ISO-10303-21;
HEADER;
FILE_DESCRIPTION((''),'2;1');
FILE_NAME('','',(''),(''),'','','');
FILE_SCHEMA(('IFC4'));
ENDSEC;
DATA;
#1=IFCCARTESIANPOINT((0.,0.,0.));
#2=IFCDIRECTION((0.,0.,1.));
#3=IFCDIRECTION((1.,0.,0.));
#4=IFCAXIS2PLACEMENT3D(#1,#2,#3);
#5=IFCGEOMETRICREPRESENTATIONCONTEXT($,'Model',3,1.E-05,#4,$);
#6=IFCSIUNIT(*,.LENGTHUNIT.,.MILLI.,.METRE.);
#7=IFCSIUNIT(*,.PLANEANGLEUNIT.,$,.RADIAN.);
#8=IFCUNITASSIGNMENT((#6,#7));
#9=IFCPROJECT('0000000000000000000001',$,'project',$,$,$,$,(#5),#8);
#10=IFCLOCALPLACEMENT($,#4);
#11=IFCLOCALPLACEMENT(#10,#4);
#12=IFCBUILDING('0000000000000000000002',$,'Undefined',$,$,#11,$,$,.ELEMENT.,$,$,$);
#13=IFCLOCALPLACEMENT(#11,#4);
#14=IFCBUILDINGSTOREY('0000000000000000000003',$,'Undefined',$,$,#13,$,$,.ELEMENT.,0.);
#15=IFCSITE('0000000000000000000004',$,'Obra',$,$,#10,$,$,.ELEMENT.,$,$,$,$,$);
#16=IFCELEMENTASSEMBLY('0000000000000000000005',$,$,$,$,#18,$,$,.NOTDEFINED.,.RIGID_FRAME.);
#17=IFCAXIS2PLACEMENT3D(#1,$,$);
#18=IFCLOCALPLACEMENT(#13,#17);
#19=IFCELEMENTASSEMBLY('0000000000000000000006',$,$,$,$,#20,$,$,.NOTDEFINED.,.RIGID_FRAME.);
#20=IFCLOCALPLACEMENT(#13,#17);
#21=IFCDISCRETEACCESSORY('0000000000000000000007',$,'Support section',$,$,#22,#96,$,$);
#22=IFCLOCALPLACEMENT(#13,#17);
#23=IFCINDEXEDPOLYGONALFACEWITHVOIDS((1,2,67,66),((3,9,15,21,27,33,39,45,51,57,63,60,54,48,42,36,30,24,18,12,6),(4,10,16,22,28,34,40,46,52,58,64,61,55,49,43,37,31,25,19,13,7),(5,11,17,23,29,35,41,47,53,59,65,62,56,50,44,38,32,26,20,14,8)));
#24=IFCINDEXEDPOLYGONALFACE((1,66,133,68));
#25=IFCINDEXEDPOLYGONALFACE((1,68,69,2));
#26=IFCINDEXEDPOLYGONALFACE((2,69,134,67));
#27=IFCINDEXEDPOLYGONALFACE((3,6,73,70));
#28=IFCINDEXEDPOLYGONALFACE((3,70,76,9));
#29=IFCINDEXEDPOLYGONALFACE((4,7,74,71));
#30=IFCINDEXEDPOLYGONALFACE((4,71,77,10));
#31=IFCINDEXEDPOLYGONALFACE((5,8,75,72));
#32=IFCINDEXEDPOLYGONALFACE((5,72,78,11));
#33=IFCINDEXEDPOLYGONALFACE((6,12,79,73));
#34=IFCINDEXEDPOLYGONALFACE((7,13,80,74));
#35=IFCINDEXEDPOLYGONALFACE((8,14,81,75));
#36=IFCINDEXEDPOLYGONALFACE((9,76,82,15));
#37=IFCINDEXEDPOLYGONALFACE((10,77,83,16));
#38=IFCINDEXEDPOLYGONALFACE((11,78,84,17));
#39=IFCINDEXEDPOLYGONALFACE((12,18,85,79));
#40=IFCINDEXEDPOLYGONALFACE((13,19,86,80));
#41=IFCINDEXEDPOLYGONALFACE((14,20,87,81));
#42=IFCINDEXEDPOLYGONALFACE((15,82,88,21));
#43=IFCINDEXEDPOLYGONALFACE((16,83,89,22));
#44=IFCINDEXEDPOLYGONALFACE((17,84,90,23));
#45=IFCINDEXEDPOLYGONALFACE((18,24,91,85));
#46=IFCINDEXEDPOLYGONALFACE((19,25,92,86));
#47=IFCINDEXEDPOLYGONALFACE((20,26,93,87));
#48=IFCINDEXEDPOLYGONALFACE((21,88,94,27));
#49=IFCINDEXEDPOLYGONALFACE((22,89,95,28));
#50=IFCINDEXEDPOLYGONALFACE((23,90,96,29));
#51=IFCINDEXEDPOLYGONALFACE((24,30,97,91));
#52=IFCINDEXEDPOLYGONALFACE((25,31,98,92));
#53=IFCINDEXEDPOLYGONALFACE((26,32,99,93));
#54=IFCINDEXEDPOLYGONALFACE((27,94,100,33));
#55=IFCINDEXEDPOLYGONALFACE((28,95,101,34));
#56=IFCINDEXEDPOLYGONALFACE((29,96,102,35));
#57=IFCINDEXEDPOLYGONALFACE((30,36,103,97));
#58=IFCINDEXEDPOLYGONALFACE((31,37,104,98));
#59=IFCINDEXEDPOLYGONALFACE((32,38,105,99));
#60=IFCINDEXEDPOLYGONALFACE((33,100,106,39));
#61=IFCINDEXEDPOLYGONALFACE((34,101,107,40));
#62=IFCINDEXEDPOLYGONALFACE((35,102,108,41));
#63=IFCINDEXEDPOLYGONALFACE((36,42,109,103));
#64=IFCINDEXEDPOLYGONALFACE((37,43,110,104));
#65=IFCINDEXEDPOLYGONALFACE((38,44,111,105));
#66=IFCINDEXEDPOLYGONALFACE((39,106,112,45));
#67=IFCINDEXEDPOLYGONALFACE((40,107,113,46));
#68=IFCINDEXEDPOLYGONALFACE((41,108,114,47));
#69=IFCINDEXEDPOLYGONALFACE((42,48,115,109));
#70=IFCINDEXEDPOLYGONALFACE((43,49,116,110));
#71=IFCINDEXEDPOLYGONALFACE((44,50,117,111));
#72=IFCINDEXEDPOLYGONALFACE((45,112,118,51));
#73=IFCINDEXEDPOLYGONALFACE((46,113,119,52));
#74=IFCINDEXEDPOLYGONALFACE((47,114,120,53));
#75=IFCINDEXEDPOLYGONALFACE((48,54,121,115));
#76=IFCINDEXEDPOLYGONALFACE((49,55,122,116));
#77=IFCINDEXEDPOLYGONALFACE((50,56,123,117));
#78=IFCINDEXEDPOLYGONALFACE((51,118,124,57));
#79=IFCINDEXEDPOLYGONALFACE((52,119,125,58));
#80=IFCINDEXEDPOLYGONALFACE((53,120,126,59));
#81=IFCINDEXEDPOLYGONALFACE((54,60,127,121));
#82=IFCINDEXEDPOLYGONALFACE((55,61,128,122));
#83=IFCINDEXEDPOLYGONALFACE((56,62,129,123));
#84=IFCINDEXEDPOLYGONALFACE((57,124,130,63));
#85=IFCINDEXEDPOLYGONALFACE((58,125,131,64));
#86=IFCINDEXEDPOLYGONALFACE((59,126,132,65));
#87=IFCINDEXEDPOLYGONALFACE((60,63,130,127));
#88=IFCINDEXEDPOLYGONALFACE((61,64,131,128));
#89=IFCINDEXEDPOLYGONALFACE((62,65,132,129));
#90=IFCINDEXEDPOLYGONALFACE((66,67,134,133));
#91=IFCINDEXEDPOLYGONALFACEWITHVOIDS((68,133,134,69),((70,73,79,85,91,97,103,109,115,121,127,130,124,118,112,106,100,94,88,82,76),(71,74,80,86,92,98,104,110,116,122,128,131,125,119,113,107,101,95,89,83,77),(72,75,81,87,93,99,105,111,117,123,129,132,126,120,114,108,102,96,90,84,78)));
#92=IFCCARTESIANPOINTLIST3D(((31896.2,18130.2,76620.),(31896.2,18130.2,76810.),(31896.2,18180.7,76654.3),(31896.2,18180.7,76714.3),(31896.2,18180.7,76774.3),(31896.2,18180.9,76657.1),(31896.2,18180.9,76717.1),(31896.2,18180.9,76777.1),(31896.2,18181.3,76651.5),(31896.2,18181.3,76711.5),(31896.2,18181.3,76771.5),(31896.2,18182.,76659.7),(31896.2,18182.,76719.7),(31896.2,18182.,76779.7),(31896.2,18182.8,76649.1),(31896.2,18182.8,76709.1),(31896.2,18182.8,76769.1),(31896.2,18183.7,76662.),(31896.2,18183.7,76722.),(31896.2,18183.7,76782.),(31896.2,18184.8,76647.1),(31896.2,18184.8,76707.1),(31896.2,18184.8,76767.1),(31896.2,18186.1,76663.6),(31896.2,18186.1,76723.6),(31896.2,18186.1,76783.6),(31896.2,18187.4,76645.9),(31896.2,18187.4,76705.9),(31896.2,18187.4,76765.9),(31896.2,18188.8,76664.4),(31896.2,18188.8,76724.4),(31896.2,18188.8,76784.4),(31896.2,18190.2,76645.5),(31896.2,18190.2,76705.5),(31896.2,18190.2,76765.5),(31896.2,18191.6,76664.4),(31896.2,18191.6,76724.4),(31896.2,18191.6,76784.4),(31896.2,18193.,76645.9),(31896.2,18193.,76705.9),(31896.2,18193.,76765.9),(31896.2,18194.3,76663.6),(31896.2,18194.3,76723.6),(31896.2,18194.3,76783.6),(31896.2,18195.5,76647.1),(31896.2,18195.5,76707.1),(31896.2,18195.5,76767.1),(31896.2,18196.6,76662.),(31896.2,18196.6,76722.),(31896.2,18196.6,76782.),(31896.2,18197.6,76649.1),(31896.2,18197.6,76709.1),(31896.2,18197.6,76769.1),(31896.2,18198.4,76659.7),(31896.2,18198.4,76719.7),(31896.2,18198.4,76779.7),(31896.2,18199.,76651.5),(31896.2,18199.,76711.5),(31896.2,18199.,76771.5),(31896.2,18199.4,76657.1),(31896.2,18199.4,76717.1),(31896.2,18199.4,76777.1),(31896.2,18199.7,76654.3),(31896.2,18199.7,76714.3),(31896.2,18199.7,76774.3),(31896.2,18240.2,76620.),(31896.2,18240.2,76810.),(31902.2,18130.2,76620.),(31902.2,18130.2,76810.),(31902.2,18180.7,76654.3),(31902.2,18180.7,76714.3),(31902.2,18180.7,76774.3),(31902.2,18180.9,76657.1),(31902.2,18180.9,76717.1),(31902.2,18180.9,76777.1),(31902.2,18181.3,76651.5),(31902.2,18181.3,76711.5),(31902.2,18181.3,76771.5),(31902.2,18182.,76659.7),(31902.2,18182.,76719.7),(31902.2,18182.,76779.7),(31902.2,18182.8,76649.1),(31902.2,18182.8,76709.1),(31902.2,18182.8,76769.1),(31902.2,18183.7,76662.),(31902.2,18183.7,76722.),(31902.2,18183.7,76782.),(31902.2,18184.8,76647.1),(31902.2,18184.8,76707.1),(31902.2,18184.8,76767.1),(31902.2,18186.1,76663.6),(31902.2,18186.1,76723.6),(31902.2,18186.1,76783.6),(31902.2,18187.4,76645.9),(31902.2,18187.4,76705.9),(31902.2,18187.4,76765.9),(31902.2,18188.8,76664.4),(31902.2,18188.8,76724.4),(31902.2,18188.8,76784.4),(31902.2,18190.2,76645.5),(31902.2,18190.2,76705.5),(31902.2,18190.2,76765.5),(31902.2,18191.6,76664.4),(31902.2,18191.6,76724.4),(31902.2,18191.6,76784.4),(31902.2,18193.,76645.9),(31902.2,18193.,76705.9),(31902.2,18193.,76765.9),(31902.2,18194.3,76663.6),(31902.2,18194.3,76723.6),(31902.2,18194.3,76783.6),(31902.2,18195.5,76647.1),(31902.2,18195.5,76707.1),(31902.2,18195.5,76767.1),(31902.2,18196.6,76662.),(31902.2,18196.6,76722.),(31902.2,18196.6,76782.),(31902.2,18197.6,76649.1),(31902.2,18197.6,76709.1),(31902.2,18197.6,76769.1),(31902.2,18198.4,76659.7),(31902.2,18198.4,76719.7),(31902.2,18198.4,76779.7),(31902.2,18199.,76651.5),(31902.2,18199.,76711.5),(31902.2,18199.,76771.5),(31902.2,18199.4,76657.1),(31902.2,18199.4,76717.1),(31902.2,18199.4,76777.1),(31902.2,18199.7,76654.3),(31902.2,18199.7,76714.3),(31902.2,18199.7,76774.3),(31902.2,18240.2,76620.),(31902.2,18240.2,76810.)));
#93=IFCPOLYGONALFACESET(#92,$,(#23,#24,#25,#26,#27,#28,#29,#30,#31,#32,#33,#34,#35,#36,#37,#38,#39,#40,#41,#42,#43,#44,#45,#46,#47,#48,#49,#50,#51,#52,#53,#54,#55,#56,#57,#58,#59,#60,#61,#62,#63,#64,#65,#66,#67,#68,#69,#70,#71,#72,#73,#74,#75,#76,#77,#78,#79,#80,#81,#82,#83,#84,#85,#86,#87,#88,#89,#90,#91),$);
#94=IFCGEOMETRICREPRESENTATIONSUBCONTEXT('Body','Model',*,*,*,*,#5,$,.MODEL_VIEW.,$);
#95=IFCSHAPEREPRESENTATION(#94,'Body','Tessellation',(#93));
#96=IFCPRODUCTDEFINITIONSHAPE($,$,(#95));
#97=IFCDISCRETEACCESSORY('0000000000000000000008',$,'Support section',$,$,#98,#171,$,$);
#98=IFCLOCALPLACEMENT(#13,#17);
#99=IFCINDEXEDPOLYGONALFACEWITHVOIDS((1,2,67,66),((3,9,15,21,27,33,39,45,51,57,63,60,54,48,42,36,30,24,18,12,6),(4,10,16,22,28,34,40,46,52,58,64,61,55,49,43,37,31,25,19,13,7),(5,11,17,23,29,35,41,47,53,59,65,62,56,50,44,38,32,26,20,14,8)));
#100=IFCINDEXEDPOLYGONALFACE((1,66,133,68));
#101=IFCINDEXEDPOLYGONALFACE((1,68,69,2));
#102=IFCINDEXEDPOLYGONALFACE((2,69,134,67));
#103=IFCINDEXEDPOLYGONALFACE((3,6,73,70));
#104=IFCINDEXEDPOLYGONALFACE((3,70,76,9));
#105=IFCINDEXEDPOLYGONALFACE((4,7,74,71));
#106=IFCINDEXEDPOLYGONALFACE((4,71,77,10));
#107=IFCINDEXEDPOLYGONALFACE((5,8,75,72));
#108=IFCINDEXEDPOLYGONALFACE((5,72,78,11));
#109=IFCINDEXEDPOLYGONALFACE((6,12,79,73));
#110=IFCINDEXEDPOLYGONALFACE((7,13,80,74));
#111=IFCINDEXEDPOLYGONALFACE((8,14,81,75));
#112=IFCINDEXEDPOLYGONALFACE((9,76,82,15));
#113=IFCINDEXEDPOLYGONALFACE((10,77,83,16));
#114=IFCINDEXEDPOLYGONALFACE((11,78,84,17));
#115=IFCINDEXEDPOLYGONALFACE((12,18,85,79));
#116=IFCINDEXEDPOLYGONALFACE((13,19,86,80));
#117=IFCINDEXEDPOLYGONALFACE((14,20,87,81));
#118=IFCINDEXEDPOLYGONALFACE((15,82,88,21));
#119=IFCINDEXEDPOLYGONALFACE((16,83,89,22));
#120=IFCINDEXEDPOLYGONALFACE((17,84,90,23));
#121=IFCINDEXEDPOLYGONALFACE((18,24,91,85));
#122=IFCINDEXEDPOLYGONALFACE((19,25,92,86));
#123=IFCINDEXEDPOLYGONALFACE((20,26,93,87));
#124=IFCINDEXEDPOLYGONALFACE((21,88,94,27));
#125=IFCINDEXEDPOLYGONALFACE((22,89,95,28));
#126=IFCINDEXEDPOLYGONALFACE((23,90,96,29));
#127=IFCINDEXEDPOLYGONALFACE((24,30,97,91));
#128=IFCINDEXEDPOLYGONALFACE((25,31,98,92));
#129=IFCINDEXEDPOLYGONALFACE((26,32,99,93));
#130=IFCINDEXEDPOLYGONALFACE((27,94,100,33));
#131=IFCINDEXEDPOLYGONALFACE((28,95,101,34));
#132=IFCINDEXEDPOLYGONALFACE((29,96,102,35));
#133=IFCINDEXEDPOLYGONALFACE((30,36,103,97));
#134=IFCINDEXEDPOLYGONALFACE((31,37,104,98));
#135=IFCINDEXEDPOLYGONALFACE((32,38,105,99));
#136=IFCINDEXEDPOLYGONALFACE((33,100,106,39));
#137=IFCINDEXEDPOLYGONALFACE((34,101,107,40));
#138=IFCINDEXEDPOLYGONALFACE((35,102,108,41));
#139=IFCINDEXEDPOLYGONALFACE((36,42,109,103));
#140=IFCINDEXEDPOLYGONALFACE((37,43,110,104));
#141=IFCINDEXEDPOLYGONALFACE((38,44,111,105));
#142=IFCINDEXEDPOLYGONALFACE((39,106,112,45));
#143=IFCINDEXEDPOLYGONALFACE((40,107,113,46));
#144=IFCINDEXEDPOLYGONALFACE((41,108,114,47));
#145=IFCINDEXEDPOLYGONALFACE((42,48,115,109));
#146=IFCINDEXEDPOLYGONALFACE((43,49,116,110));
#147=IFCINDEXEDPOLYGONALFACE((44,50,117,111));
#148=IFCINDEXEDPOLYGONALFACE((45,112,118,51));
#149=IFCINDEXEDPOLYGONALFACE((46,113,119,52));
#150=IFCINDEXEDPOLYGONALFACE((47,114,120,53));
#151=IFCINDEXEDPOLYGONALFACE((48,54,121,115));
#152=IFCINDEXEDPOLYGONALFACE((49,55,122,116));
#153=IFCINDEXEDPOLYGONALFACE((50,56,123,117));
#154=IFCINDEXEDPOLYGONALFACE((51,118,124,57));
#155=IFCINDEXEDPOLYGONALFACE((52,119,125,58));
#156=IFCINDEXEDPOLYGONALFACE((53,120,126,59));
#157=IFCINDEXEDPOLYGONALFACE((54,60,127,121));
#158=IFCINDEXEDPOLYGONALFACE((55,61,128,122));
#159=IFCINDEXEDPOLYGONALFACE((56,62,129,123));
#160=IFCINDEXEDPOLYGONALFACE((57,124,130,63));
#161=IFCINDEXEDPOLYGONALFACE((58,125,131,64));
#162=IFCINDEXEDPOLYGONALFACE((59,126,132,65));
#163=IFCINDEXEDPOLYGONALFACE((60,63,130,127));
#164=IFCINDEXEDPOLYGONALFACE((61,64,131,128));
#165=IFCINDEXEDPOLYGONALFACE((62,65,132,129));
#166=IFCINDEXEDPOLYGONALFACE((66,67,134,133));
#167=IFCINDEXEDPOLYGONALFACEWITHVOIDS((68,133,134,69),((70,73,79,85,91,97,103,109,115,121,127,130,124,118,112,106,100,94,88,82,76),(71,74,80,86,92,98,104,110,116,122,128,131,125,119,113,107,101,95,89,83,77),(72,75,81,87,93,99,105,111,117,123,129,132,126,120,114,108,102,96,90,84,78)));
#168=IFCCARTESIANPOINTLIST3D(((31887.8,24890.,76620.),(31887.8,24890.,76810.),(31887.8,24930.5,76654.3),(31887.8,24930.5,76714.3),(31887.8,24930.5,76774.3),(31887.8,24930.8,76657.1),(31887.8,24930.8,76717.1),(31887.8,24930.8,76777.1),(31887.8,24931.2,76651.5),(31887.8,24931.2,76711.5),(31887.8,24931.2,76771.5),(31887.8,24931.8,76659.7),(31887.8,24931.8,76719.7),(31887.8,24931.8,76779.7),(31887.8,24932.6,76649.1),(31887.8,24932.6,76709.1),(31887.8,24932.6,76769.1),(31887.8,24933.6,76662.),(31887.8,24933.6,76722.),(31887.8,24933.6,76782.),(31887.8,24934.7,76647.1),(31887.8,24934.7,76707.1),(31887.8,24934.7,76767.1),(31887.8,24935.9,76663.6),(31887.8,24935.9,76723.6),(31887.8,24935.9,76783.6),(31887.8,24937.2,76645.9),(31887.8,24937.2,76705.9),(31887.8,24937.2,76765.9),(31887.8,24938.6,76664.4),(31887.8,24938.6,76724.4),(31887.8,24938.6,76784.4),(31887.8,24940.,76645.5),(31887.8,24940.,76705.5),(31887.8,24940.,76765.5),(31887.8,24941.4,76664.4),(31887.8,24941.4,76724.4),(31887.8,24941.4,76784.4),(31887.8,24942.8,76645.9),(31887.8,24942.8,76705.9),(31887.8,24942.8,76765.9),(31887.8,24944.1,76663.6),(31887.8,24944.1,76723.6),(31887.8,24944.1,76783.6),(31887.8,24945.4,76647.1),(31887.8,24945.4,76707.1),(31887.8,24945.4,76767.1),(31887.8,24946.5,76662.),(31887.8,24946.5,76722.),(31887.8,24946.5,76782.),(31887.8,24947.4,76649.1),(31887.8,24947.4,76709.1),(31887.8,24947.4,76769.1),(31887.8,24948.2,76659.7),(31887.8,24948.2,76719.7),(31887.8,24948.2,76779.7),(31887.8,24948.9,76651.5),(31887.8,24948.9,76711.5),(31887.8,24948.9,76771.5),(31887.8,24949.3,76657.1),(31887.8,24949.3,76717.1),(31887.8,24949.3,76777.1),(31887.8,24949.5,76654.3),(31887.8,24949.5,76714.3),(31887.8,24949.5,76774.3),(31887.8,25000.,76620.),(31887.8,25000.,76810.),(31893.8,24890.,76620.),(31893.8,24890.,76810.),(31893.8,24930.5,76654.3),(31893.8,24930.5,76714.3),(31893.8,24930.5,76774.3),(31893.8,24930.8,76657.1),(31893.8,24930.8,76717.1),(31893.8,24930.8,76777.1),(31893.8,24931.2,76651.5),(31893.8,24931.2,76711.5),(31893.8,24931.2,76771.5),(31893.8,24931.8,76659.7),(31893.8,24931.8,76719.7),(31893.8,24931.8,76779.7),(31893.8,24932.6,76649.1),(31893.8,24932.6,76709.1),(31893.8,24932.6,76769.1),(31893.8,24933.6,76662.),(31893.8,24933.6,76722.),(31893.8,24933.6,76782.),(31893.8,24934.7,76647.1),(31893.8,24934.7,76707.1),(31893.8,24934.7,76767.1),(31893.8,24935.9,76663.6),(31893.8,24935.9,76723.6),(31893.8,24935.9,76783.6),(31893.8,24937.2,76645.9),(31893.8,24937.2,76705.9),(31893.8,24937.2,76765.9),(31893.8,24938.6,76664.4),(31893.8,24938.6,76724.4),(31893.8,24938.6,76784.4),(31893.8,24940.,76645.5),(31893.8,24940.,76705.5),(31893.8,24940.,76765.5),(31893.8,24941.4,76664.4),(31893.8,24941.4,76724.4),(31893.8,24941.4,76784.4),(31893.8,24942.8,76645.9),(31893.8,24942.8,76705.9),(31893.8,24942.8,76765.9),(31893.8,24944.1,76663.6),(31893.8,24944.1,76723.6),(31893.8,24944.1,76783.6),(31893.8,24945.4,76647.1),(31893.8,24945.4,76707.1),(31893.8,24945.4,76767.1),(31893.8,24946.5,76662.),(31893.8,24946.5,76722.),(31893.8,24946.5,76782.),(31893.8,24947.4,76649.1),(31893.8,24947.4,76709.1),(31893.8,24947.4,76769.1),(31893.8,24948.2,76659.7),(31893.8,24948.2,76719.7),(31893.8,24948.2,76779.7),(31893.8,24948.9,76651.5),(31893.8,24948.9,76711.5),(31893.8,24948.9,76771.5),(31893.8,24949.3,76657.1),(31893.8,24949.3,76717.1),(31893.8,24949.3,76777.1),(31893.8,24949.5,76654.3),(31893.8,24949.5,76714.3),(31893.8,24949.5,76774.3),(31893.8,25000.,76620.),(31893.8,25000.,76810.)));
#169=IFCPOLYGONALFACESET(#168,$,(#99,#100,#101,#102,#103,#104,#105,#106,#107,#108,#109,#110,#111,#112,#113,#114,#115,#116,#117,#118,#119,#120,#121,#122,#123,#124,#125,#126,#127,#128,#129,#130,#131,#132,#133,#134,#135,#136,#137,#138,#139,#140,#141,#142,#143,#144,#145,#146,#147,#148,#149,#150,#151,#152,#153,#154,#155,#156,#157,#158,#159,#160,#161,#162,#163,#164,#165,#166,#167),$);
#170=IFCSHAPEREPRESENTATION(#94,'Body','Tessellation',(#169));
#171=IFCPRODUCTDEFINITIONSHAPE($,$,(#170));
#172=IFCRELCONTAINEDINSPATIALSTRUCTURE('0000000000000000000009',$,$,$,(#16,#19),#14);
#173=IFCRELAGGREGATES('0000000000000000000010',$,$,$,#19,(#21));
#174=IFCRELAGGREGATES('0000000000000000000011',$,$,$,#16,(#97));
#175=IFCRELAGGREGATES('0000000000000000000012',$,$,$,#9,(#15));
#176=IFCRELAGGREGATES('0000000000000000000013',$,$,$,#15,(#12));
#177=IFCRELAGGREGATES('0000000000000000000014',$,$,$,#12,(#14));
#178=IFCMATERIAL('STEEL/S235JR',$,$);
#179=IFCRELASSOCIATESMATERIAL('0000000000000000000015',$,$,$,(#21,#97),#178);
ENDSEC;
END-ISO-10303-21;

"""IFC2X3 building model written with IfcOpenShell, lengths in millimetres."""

from ifc_helpers import new_model, si_unit, frame, origin_with_axes, origin_2d_with_axis, place, context, subcontext, project, spatial, rectangle, circle, extrude, source, transform, mapped, material, element, aggregate, save


model = new_model("IFC2X3")

# Units and contexts
model_context = context("Model", 3, precision=1e-05, world=origin_with_axes())
body_context = subcontext(model_context, "Body", "Model", "MODEL_VIEW")
ifc_project = project(units=[si_unit("LENGTHUNIT", "METRE", prefix="MILLI"), si_unit("PLANEANGLEUNIT", "RADIAN")], contexts=[model_context])

# Site, building, storey
site_placement = place(None, origin_with_axes())
site = spatial("IfcSite", under=ifc_project, at=site_placement, Name="Obra", CompositionType="ELEMENT")
building_placement = place(site_placement, origin_with_axes())
building = spatial("IfcBuilding", under=site, at=building_placement, Name="Undefined", CompositionType="ELEMENT")
storey_placement = place(building_placement, origin_with_axes())
storey = spatial("IfcBuildingStorey", under=building, at=storey_placement, Name="Undefined", CompositionType="ELEMENT", Elevation=0.0)

# Element assembly
assembly_1_placement = place(storey_placement, origin_with_axes())
assembly_1 = element("IfcElementAssembly", 1, at=assembly_1_placement, inside=storey, AssemblyPlace="NOTDEFINED", PredefinedType="RIGID_FRAME")
ifc_material = material(Name="STEEL/S235JR")

# Element assembly, discrete accessory, opening
shared_shape_1 = source(origin_with_axes(), body_context, "Body", "SweptSolid", [
    extrude(circle(Radius=9.5, at=origin_2d_with_axis()), frame((0.0, -9.2, 0.0), z_axis=(0.0, 1.0, 0.0), x_axis=(1.0, 0.0, 0.0)), (0.0, 0.0, 1.0), 6.2),
])
assembly_2_placement = place(storey_placement, origin_with_axes())
assembly_2 = element("IfcElementAssembly", 2, at=assembly_2_placement, inside=storey, AssemblyPlace="NOTDEFINED", PredefinedType="RIGID_FRAME")
discrete_accessory_1_placement = place(assembly_2_placement, frame((31899.2, 18185.2, 76620.0), z_axis=(0.0, 0.0, 1.0), x_axis=(0.000002, -1.0, 0.0)))
discrete_accessory_1 = element("IfcDiscreteAccessory", 3, at=discrete_accessory_1_placement, material=ifc_material, Name="Support section", context=body_context, shape_type="SweptSolid", body=[
    extrude(rectangle(XDim=6.0, YDim=110.0, at=origin_2d_with_axis()), frame((0.0, 0.0, 190.0), z_axis=(0.0, 0.0, -1.0), x_axis=(0.0, 1.0, 0.0)), (0.0, 0.0, 1.0), 190.0),
])
opening_1_placement = place(assembly_2_placement, frame((31893.1, 18140.2, 76835.0), z_axis=(-0.000002, 1.0, 0.0), x_axis=(0.0, 0.0, -1.0)))
element("IfcOpeningElement", 4, at=opening_1_placement, cuts=discrete_accessory_1, ObjectType="Opening", context=body_context, shape_type="MappedRepresentation", body=[
    mapped(shared_shape_1, transform((60.0, 0.0, 50.0))),
    mapped(shared_shape_1, transform((120.0, 0.0, 50.0))),
    mapped(shared_shape_1, transform((180.0, 0.0, 50.0))),
])
aggregate(assembly_2, [discrete_accessory_1])

# Discrete accessory, opening
discrete_accessory_2_placement = place(assembly_1_placement, frame((31890.8, 24945.0, 76620.0), z_axis=(0.0, 0.0, 1.0), x_axis=(-0.000002, 1.0, 0.0)))
discrete_accessory_2 = element("IfcDiscreteAccessory", 5, at=discrete_accessory_2_placement, material=ifc_material, Name="Support section", context=body_context, shape_type="SweptSolid", body=[
    extrude(rectangle(XDim=6.0, YDim=110.0, at=origin_2d_with_axis()), frame((0.0, 0.0, 190.0), z_axis=(0.0, 0.0, -1.0), x_axis=(0.0, 1.0, 0.0)), (0.0, 0.0, 1.0), 190.0),
])
opening_2_placement = place(assembly_1_placement, frame((31896.9, 24990.0, 76835.0), z_axis=(0.000002, -1.0, 0.0), x_axis=(0.0, 0.0, -1.0)))
element("IfcOpeningElement", 6, at=opening_2_placement, cuts=discrete_accessory_2, ObjectType="Opening", context=body_context, shape_type="MappedRepresentation", body=[
    mapped(shared_shape_1, transform((60.0, 0.0, 50.0))),
    mapped(shared_shape_1, transform((120.0, 0.0, 50.0))),
    mapped(shared_shape_1, transform((180.0, 0.0, 50.0))),
])
aggregate(assembly_1, [discrete_accessory_2])

save(model, "model.ifc")
